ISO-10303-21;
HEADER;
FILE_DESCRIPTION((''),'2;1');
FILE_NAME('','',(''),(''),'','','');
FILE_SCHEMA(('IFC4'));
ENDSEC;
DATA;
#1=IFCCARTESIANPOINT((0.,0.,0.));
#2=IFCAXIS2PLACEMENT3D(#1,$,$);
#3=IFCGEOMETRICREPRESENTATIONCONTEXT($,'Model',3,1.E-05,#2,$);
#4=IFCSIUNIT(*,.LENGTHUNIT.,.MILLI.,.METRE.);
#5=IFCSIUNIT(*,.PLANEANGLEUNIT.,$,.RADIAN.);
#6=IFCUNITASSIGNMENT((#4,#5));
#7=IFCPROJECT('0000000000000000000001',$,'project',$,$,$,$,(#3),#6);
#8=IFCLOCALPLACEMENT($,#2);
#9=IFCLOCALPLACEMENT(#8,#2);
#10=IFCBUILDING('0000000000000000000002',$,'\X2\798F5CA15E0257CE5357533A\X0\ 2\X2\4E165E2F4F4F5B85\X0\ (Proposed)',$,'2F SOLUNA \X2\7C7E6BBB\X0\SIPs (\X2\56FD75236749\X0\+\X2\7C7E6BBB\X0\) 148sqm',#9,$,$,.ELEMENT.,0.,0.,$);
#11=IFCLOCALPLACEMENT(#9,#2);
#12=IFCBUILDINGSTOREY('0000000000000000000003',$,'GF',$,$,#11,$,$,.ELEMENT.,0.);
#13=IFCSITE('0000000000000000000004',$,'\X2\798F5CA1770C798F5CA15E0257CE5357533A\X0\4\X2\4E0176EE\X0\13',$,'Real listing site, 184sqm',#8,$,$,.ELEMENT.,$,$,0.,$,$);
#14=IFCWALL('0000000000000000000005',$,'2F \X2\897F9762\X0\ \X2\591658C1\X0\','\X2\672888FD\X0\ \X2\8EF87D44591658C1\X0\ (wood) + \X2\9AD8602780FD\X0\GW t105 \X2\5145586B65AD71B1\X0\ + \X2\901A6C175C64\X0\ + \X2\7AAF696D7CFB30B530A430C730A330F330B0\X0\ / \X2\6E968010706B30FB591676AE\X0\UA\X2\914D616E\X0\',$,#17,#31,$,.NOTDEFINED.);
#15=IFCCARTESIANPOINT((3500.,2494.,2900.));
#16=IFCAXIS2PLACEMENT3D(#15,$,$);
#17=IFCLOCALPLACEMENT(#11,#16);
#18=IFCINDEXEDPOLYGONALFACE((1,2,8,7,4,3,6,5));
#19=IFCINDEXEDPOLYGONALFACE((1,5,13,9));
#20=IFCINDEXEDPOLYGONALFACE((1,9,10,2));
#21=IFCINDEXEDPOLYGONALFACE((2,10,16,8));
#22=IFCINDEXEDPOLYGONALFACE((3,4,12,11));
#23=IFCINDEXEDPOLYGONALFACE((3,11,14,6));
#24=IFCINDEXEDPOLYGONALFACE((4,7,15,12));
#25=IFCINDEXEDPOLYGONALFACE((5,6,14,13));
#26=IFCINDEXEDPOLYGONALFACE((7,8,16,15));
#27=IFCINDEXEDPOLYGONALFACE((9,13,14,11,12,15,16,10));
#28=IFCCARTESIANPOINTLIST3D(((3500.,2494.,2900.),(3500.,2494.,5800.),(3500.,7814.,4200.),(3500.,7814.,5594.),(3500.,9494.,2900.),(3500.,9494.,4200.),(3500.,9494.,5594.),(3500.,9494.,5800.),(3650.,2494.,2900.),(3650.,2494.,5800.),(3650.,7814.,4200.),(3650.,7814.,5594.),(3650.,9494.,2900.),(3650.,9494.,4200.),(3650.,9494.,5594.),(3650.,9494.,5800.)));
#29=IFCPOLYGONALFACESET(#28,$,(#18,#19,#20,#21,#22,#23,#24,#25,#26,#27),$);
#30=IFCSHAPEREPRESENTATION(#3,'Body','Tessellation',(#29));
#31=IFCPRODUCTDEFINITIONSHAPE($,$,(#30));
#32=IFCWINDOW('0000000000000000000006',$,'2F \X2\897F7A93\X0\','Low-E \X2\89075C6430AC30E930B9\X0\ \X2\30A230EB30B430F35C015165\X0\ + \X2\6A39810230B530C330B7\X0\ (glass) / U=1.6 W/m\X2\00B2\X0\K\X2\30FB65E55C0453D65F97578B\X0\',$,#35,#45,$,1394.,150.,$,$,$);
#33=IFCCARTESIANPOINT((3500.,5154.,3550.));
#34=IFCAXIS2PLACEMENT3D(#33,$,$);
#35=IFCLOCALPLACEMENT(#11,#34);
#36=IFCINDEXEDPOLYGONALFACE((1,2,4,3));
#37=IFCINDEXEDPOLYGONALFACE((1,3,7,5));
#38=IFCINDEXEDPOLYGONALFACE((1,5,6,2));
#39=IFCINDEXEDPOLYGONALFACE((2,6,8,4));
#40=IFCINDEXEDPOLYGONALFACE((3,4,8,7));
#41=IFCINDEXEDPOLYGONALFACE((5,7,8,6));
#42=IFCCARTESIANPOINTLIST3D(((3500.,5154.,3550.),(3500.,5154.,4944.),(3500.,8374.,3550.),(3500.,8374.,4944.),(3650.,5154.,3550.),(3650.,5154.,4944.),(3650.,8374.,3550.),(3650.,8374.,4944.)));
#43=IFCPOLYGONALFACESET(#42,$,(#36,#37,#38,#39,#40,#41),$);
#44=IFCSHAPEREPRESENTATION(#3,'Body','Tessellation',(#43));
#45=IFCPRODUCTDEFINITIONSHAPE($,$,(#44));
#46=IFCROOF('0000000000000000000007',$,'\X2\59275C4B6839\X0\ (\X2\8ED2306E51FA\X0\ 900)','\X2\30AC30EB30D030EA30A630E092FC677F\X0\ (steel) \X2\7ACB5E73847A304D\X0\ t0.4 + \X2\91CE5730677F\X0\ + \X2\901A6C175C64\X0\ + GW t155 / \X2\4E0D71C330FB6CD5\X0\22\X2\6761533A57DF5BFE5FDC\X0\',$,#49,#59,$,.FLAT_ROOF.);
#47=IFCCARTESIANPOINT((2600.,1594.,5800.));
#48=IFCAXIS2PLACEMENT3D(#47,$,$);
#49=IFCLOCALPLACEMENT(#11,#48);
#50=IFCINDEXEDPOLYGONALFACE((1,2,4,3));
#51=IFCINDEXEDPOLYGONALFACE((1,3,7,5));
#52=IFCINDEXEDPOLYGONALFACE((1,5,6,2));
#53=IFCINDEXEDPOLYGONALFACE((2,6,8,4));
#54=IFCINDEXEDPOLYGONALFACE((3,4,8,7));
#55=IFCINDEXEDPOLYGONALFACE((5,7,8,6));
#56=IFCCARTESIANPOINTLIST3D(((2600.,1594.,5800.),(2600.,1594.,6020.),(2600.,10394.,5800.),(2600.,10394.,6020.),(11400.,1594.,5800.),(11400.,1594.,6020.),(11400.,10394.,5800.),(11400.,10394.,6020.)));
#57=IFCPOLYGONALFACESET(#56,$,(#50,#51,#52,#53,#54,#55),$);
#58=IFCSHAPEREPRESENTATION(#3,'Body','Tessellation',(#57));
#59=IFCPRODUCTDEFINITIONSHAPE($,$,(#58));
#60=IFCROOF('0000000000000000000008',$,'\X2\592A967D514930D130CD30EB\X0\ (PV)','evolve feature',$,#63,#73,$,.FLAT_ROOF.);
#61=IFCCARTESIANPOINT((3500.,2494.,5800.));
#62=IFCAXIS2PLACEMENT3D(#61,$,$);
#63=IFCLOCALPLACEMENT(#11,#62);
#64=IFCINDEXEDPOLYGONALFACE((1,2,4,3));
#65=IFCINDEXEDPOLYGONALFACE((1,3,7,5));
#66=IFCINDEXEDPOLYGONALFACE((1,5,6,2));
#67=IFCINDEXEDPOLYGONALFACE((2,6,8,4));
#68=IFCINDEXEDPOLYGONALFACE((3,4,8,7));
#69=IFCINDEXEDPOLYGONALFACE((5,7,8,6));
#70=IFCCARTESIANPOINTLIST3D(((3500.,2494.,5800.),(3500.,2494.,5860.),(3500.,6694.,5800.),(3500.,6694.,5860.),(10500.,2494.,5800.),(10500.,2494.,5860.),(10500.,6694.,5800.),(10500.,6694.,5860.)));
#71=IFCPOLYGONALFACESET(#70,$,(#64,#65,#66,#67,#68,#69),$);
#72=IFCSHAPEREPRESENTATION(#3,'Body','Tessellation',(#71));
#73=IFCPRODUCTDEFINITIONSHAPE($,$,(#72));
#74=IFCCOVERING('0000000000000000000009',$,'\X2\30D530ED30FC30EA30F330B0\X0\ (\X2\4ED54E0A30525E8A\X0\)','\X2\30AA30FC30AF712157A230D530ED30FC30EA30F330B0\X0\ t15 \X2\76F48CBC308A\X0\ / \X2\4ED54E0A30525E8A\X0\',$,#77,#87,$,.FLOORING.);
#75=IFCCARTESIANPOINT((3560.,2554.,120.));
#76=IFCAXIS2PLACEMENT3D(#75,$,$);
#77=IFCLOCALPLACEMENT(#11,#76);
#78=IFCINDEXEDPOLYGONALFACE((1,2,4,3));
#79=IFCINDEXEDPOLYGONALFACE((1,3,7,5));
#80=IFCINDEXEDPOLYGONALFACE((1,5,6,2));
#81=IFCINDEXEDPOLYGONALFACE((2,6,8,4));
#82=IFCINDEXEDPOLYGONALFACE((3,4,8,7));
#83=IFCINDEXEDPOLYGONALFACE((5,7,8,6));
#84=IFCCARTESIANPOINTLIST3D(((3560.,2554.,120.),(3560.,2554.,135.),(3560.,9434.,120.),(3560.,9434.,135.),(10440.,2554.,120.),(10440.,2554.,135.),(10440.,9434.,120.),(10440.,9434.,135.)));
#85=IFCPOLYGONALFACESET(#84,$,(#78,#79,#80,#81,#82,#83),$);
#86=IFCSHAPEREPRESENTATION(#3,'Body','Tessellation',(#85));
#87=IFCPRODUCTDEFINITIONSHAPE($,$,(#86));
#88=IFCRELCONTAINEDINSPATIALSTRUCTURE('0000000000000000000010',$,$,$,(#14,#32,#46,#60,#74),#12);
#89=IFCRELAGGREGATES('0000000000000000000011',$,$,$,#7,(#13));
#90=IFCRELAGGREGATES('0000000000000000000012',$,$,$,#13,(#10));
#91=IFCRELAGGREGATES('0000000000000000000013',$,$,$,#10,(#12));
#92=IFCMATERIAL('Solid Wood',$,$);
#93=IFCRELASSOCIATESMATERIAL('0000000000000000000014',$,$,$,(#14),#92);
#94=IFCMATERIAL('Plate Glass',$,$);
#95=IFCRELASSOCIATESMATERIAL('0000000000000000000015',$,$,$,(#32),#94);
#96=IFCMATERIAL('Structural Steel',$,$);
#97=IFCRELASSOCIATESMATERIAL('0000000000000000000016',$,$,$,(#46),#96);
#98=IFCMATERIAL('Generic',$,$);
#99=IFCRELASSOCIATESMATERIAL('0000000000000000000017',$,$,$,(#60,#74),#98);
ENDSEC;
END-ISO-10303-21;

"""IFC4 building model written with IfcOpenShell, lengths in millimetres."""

from ifc_helpers import new_model, si_unit, frame, frame_2d, origin, place, context, project, spatial, rectangle, extrude, material, element, fill, save


model = new_model("IFC4")

# Units and contexts
model_context = context("Model", 3, precision=1e-05, world=origin())
ifc_project = project(units=[si_unit("LENGTHUNIT", "METRE", prefix="MILLI"), si_unit("PLANEANGLEUNIT", "RADIAN")], contexts=[model_context])

# Site, building, storey
site_placement = place(None, origin())
site = spatial("IfcSite", under=ifc_project, at=site_placement, Name="福岡県福岡市城南区4丁目13", ObjectType="Real listing site, 184sqm", CompositionType="ELEMENT", RefElevation=0.0)
building_placement = place(site_placement, origin())
building = spatial("IfcBuilding", under=site, at=building_placement, Name="福岡市城南区 2世帯住宅 (Proposed)", ObjectType="2F SOLUNA 籾殻SIPs (国産杉+籾殻) 148sqm", CompositionType="ELEMENT", ElevationOfRefHeight=0.0, ElevationOfTerrain=0.0)
storey_placement = place(building_placement, origin())
storey = spatial("IfcBuildingStorey", under=building, at=storey_placement, Name="GF", CompositionType="ELEMENT", Elevation=0.0)

# Shared definitions
ifc_material_1 = material(Name="Solid Wood")
ifc_material_2 = material(Name="Generic")

# Shared definitions
ifc_material_3 = material(Name="Plate Glass")

# Wall, opening, window
wall_1_placement = place(storey_placement, frame((3500.0, 2494.0, 2900.0)))
wall_1 = element("IfcWall", 1, at=wall_1_placement, inside=storey, material=ifc_material_1, Name="2F 西面 外壁", Description="木製 軸組外壁 (wood) + 高性能GW t105 充填断熱 + 通気層 + 窯業系サイディング / 準耐火・外皮UA配慮", PredefinedType="NOTDEFINED", context=model_context, shape_type="SweptSolid", body=[
    extrude(rectangle(XDim=150.0, YDim=7000.0, at=frame_2d((75.0, 3500.0))), frame((3500.0, 2494.0, 2900.0)), (0.0, 0.0, 1.0), 2900.0),
])
opening_1_placement = place(storey_placement, frame((3500.0, 5154.0, 3550.0)))
opening_1 = element("IfcOpeningElement", 2, at=opening_1_placement, cuts=wall_1, PredefinedType="NOTDEFINED", context=model_context, shape_type="SweptSolid", body=[
    extrude(rectangle(XDim=150.0, YDim=3220.0, at=frame_2d((75.0, 1610.0))), frame((3500.0, 5154.0, 3550.0)), (0.0, 0.0, 1.0), 1394.0),
])
window_1_placement = place(storey_placement, frame((3500.0, 5154.0, 3550.0)))
window_1 = element("IfcWindow", 3, at=window_1_placement, inside=storey, material=ifc_material_3, Name="2F 西窓", Description="Low-E 複層ガラス アルゴン封入 + 樹脂サッシ (glass) / U=1.6 W/m²K・日射取得型", OverallHeight=1394.0, OverallWidth=150.0, context=model_context, shape_type="SweptSolid", body=[
    extrude(rectangle(XDim=150.0, YDim=3220.0, at=frame_2d((75.0, 1610.0))), frame((3500.0, 5154.0, 3550.0)), (0.0, 0.0, 1.0), 1394.0),
])
fill(opening_1, window_1)

# Roofs
ifc_material_4 = material(Name="Structural Steel")
roof_1_placement = place(storey_placement, frame((2600.0, 1594.0, 5800.0)))
element("IfcRoof", 4, at=roof_1_placement, inside=storey, material=ifc_material_4, Name="大屋根 (軒の出 900)", Description="ガルバリウム鋼板 (steel) 立平葺き t0.4 + 野地板 + 通気層 + GW t155 / 不燃・法22条区域対応", PredefinedType="FLAT_ROOF", context=model_context, shape_type="SweptSolid", body=[
    extrude(rectangle(XDim=8800.0, YDim=8800.0, at=frame_2d((4400.0, 4400.0))), frame((2600.0, 1594.0, 5800.0)), (0.0, 0.0, 1.0), 220.0),
])
roof_2_placement = place(storey_placement, frame((3500.0, 2494.0, 5800.0)))
element("IfcRoof", 5, at=roof_2_placement, inside=storey, material=ifc_material_2, Name="太陽光パネル (PV)", Description="evolve feature", PredefinedType="FLAT_ROOF", context=model_context, shape_type="SweptSolid", body=[
    extrude(rectangle(XDim=7000.0, YDim=4200.0, at=frame_2d((3500.0, 2100.0))), frame((3500.0, 2494.0, 5800.0)), (0.0, 0.0, 1.0), 60.0),
])

# Covering
covering_placement = place(storey_placement, frame((3560.0, 2554.0, 120.0)))
element("IfcCovering", 6, at=covering_placement, inside=storey, material=ifc_material_2, Name="フローリング (仕上げ床)", Description="オーク無垢フローリング t15 直貼り / 仕上げ床", PredefinedType="FLOORING", context=model_context, shape_type="SweptSolid", body=[
    extrude(rectangle(XDim=6880.0, YDim=6880.0, at=frame_2d((3440.0, 3440.0))), frame((3560.0, 2554.0, 120.0)), (0.0, 0.0, 1.0), 15.0),
])

save(model, "model.ifc")
